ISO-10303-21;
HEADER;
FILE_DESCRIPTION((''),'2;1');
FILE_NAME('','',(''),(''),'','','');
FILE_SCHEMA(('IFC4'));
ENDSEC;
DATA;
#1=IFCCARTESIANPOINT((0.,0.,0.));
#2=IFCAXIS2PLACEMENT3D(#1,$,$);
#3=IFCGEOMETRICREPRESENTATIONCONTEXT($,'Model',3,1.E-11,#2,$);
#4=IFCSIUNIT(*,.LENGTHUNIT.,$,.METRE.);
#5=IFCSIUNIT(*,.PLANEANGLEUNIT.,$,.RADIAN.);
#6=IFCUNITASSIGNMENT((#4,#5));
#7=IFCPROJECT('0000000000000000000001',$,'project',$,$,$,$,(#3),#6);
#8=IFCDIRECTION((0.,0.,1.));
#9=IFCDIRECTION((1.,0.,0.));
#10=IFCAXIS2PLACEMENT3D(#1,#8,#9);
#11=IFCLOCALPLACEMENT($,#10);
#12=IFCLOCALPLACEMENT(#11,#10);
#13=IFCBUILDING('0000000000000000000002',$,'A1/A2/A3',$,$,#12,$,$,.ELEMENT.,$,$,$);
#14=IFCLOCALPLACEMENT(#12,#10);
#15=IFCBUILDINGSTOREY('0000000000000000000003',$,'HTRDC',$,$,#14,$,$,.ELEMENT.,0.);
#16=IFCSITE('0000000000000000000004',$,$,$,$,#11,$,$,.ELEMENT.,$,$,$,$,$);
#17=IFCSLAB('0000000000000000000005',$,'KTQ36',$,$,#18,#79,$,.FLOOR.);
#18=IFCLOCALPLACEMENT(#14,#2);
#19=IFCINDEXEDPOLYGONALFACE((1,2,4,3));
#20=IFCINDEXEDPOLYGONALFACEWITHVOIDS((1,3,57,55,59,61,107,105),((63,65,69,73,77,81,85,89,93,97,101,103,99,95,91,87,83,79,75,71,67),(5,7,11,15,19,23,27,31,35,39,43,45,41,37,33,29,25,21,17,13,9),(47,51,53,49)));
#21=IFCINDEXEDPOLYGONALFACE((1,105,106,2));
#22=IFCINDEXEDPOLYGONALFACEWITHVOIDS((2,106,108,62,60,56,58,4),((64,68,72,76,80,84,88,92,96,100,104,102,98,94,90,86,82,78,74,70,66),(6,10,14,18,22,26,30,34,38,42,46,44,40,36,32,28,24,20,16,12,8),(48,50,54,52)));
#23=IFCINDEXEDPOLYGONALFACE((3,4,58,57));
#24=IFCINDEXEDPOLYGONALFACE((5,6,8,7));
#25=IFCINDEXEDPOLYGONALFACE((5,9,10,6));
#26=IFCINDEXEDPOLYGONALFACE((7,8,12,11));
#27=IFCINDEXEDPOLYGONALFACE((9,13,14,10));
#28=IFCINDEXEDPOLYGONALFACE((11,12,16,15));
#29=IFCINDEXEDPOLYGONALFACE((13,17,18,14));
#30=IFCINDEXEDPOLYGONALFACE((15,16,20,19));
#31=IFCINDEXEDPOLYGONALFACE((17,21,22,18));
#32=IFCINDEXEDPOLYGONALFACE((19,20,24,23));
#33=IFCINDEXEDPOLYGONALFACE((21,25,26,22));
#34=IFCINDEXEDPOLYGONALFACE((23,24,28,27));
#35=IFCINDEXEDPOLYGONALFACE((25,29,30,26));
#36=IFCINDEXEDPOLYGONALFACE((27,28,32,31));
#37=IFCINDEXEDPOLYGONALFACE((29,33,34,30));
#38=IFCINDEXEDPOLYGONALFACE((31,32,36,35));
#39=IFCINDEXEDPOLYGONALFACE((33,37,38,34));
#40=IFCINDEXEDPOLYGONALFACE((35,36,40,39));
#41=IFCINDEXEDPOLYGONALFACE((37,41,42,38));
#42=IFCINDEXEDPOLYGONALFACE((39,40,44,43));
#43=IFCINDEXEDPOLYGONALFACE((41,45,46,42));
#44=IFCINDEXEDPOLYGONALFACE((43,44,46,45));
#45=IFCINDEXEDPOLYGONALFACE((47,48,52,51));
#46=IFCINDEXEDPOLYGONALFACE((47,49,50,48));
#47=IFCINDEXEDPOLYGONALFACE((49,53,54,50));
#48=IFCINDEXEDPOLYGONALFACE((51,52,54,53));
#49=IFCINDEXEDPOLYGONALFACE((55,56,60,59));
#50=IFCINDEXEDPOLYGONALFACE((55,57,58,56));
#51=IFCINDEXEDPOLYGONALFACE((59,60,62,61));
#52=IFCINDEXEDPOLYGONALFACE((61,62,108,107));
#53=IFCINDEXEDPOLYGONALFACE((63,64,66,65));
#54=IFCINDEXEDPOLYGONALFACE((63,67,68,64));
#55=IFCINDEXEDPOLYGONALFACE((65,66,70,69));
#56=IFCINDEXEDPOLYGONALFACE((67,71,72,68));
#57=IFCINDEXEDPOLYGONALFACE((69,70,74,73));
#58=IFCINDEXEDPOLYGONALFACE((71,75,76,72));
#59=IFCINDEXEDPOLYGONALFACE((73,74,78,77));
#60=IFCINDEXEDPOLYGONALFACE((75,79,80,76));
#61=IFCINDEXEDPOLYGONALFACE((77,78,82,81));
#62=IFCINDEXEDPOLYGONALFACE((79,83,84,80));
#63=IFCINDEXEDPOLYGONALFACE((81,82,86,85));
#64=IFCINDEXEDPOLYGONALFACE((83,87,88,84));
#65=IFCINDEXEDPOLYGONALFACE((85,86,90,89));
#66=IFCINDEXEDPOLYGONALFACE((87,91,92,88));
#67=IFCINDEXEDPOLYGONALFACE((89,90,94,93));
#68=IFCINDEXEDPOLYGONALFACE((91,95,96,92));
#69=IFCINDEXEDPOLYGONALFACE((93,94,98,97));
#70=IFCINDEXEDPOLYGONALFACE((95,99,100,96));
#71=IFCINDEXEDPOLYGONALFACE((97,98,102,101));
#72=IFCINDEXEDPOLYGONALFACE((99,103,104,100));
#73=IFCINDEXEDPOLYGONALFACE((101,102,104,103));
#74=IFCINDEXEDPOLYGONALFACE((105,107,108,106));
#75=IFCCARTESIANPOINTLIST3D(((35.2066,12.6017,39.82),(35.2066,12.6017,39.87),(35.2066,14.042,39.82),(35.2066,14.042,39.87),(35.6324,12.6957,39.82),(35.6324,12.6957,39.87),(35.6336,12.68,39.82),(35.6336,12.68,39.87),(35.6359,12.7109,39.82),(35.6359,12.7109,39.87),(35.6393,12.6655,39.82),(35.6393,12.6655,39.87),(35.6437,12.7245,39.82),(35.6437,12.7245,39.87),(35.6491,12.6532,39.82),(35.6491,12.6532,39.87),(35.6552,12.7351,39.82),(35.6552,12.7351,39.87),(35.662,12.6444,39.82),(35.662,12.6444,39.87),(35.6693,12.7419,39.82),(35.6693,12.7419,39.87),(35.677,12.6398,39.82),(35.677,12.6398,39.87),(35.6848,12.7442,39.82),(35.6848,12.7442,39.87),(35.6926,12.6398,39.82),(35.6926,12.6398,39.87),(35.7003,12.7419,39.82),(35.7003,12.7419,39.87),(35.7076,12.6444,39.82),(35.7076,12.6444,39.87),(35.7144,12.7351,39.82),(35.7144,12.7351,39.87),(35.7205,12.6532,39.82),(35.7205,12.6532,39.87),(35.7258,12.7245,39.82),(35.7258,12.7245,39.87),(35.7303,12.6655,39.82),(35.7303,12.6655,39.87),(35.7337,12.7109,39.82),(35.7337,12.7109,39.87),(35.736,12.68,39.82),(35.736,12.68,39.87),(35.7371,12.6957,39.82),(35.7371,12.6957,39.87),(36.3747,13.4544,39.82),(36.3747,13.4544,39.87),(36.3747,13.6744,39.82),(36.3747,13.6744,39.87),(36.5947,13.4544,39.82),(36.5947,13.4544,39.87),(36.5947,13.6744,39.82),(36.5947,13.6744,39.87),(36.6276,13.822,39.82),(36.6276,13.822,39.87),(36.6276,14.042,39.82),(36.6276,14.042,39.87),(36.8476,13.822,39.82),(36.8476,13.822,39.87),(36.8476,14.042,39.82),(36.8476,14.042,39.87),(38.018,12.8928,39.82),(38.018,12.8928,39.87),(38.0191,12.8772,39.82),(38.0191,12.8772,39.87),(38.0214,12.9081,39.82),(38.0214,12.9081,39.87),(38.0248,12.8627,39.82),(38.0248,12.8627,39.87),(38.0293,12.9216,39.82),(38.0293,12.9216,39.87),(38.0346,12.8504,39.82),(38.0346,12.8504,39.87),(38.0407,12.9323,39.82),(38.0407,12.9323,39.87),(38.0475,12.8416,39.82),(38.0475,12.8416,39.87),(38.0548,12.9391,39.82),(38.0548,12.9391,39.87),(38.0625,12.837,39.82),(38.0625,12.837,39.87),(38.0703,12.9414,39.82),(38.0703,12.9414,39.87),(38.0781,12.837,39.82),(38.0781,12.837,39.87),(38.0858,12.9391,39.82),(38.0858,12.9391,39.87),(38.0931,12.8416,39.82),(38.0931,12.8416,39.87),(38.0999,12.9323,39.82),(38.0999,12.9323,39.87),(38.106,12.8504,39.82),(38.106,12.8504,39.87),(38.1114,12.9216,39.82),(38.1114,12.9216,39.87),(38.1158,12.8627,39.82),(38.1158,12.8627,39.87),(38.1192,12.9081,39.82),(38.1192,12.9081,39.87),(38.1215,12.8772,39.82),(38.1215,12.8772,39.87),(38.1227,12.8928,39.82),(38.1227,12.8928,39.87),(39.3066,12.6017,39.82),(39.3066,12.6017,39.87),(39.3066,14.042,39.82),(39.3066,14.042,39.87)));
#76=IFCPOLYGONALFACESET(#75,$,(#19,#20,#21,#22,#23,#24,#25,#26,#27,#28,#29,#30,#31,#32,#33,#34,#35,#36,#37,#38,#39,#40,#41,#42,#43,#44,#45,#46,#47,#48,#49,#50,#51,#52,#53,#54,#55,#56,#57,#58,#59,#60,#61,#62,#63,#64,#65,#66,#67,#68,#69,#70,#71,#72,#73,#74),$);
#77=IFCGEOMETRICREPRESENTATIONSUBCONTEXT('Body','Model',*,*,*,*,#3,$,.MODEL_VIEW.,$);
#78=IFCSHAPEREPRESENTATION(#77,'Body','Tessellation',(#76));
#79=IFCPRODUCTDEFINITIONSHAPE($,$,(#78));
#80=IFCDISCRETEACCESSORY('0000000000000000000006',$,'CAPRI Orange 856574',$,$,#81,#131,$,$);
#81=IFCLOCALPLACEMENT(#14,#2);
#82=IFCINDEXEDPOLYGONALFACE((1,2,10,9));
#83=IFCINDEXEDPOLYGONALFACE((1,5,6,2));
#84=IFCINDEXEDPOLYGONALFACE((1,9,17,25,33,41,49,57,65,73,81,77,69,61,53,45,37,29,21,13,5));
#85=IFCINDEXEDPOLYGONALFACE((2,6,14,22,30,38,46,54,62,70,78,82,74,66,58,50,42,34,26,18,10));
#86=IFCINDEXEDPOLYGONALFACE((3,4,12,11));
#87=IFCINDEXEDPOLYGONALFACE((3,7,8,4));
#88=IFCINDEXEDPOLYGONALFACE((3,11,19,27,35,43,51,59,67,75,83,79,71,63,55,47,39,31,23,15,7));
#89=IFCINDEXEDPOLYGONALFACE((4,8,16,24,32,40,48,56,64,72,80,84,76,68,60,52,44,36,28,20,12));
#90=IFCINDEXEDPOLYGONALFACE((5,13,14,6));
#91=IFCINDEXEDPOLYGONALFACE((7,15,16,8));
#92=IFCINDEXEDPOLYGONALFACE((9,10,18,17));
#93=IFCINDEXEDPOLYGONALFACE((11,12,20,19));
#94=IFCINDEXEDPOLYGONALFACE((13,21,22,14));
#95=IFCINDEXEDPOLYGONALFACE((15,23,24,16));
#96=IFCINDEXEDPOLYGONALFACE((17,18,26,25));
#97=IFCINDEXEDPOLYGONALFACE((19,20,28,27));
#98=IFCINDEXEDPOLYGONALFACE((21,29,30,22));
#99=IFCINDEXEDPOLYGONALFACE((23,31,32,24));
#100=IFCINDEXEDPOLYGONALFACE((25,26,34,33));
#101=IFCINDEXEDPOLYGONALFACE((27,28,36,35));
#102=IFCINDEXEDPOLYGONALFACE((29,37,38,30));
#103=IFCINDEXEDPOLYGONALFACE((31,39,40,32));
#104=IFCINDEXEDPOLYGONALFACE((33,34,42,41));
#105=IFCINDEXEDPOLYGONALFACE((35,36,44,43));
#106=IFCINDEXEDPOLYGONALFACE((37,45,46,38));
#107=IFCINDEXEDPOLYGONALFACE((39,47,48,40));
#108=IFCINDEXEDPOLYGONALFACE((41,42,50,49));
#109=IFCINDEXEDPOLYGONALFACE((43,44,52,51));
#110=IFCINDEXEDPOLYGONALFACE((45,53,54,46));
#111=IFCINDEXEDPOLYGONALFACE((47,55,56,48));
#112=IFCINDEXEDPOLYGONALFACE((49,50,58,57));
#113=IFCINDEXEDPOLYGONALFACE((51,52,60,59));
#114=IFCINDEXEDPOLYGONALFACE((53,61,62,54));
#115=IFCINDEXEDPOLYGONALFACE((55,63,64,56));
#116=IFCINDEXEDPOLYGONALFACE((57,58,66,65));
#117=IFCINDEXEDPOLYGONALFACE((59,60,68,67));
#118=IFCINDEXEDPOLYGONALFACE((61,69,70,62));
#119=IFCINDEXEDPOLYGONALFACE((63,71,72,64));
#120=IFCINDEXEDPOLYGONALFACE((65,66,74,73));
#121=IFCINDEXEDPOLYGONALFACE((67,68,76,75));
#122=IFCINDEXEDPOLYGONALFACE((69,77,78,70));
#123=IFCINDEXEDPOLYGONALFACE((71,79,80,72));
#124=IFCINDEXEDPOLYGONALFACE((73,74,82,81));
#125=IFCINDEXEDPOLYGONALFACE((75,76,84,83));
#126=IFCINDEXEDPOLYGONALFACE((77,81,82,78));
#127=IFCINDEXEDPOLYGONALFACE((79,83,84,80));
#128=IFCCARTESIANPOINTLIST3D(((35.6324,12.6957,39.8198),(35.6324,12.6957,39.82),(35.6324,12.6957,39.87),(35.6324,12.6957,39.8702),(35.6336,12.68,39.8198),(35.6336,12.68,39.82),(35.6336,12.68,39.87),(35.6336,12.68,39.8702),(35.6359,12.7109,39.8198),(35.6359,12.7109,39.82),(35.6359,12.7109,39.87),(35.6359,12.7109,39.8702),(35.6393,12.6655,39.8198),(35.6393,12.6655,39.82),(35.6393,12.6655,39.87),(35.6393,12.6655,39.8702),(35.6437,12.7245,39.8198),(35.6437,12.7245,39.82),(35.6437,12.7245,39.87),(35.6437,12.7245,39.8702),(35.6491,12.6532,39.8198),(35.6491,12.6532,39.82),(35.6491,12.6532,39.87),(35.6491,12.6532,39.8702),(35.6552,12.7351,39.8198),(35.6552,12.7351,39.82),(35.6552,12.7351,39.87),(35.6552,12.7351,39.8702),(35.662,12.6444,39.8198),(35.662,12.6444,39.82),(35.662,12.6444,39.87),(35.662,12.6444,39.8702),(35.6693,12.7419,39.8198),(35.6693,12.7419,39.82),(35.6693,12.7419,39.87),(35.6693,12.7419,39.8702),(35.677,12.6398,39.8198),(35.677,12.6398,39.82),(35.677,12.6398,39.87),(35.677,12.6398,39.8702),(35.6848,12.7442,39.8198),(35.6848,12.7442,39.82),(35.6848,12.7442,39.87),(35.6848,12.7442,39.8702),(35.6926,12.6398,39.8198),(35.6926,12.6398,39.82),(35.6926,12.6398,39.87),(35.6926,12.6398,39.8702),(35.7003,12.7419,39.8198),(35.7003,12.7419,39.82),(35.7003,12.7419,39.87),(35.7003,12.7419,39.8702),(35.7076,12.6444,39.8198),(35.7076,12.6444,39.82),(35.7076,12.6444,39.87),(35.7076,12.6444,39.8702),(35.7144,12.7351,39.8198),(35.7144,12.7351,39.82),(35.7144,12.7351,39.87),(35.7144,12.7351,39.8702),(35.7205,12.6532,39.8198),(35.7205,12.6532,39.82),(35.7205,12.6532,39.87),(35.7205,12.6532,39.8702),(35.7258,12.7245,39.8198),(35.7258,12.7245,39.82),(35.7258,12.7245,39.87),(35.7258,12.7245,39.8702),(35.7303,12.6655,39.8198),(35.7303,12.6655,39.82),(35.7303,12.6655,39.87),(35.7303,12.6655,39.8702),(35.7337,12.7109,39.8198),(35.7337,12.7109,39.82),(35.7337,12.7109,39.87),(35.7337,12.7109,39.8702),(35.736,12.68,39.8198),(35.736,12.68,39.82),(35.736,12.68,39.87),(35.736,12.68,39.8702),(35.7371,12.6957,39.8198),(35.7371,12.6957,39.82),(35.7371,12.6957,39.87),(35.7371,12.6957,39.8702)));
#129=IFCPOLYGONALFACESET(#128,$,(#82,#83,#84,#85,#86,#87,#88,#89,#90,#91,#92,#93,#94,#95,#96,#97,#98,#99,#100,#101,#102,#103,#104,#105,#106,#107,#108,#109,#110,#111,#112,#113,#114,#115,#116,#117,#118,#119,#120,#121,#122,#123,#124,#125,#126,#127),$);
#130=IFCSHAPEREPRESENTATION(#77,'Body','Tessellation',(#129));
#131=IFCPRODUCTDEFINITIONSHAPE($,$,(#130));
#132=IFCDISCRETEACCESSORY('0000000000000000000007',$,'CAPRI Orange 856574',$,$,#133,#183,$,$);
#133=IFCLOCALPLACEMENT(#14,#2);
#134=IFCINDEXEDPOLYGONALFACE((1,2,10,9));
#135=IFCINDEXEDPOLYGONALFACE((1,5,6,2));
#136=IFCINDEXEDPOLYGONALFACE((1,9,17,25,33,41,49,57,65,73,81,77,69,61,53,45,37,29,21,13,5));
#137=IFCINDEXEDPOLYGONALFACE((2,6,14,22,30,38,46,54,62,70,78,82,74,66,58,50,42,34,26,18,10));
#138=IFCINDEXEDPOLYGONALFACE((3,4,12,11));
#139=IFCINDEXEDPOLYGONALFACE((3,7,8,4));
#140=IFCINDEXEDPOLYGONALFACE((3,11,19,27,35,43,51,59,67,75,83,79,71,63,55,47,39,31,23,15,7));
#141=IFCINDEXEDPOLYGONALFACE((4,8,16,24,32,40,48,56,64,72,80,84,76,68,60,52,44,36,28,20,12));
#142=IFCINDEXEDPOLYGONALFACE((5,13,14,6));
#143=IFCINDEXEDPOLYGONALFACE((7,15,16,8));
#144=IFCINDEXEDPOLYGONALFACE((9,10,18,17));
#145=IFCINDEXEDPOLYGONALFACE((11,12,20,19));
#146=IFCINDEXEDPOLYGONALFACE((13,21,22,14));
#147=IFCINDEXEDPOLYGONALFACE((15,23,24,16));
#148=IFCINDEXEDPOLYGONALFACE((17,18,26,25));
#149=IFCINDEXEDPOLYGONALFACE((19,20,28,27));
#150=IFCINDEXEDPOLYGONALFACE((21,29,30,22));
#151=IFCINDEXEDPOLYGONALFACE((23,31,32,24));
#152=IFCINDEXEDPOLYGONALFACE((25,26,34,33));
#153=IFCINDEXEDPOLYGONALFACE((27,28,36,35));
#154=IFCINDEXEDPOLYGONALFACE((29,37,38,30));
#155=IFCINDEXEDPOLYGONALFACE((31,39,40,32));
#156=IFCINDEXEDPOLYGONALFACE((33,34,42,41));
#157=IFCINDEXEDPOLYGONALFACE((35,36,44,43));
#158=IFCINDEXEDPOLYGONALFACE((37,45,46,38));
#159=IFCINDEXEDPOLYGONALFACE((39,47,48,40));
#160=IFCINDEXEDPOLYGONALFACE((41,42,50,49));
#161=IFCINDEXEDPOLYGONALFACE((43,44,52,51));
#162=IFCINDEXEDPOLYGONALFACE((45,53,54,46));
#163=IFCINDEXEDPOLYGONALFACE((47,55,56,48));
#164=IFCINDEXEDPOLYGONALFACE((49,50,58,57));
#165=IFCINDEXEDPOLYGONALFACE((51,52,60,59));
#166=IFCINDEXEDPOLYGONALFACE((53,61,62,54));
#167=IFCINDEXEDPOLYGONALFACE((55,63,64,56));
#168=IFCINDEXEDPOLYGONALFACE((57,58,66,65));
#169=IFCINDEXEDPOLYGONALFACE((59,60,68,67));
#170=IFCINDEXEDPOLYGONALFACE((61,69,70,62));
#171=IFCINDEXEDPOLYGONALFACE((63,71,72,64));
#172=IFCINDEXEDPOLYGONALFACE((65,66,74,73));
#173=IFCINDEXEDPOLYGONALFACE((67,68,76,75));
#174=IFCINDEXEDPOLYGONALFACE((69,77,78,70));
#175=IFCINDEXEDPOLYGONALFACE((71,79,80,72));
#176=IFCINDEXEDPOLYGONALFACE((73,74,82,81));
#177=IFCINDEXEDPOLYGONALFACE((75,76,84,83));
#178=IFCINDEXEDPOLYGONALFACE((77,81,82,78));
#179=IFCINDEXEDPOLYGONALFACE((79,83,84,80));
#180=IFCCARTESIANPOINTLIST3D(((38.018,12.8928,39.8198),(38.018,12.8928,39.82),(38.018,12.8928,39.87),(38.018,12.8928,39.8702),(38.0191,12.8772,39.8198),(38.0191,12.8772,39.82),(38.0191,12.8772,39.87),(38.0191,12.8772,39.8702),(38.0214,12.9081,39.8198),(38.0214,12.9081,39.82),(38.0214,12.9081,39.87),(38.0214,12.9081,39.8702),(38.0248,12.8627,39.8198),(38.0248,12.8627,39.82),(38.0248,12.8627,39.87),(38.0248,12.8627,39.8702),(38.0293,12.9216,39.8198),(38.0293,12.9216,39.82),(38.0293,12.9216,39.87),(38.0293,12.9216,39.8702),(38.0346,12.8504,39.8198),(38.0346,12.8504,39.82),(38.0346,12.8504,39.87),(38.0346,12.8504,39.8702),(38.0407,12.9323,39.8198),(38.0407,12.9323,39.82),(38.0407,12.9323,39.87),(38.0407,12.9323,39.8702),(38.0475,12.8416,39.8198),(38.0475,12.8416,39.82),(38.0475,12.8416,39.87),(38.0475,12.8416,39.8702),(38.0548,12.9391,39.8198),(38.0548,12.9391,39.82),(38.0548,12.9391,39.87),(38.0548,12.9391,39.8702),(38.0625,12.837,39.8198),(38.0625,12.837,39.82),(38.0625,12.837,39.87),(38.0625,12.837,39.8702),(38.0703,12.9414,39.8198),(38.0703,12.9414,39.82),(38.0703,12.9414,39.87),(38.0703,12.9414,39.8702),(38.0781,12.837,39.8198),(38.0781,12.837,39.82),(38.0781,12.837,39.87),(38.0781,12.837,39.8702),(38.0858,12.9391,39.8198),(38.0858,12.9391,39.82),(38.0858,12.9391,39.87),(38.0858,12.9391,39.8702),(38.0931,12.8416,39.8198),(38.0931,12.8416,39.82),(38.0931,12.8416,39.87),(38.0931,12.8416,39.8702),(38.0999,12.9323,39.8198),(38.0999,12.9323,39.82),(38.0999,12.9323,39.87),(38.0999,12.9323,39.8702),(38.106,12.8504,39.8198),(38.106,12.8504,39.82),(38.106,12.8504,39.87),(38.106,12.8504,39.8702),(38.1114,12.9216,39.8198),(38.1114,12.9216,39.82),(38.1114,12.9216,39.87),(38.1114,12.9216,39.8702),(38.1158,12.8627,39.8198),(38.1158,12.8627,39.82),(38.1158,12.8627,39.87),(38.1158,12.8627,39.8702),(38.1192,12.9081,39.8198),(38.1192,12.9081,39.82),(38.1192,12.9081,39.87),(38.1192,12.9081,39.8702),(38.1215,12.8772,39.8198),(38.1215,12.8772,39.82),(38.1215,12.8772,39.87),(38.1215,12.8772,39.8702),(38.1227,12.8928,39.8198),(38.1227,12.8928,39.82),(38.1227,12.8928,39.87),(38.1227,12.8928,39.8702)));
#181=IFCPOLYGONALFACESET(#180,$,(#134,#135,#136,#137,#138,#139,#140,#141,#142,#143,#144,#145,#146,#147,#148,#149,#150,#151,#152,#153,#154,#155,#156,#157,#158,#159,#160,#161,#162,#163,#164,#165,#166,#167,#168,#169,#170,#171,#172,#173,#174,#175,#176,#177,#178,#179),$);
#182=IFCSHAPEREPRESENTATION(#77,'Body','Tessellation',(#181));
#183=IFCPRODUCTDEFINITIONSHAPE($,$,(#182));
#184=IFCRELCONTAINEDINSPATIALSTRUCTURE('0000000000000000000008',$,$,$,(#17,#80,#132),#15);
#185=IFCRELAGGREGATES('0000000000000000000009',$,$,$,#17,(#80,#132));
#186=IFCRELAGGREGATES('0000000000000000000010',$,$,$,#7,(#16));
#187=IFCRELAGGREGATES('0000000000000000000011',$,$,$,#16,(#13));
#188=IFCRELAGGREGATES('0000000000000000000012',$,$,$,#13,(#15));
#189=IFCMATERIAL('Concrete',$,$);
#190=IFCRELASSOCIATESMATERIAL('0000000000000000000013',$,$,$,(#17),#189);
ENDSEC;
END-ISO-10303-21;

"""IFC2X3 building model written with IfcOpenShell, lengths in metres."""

from ifc_helpers import new_model, si_unit, frame, frame_2d, origin, origin_with_axes, origin_2d_with_axis, place, context, subcontext, project, spatial, polyline, circle, outline, extrude, material, element, aggregate, save


model = new_model("IFC2X3")

# Units and contexts
model_context = context("Model", 3, precision=1e-11, world=origin())
body_context = subcontext(model_context, "Body", "Model", "MODEL_VIEW")
ifc_project = project(units=[si_unit("LENGTHUNIT", "METRE"), si_unit("PLANEANGLEUNIT", "RADIAN")], contexts=[model_context])

# Site, building, storey
site_placement = place(None, origin_with_axes())
site = spatial("IfcSite", under=ifc_project, at=site_placement, CompositionType="ELEMENT")
building_placement = place(site_placement, origin_with_axes())
building = spatial("IfcBuilding", under=site, at=building_placement, Name="A1/A2/A3", CompositionType="ELEMENT")
storey_placement = place(building_placement, origin_with_axes())
storey = spatial("IfcBuildingStorey", under=building, at=storey_placement, Name="HTRDC", CompositionType="ELEMENT", Elevation=0.0)

# Shared definitions
ifc_material = material(Name="Concrete")

# Slab, openings
slab_1_placement = place(storey_placement, frame((35.2066, 12.6017, 39.82), z_axis=(0.0, 0.0, 1.0), x_axis=(1.0, 0.0, 0.0)))
slab_1 = element("IfcSlab", 1, at=slab_1_placement, inside=storey, material=ifc_material, Name="KTQ36", PredefinedType="FLOOR", context=body_context, shape_type="SweptSolid", body=[
    extrude(outline(polyline([(0.0, 0.0), (0.0, -4.1), (1.4403, -4.1), (1.4403, 0.0), (0.0, 0.0)])), frame((0.0, 0.0, 0.0), z_axis=(0.0, 0.0, 1.0), x_axis=(0.0, 1.0, 0.0)), (0.0, 0.0, 1.0), 0.05),
])
opening_1_placement = place(slab_1_placement, origin_with_axes())
element("IfcOpeningElement", 2, at=opening_1_placement, cuts=slab_1, ObjectType="Opening", context=body_context, shape_type="SweptSolid", body=[
    extrude(outline(polyline([(1.2203, -1.421), (1.2203, -1.641), (1.4403, -1.641), (1.4403, -1.421), (1.2203, -1.421)])), frame((0.0, 0.0, 0.0), z_axis=(0.0, 0.0, 1.0), x_axis=(0.0, 1.0, 0.0)), (0.0, 0.0, 1.0), 0.05),
])
opening_2_placement = place(slab_1_placement, origin_with_axes())
element("IfcOpeningElement", 3, at=opening_2_placement, cuts=slab_1, ObjectType="Opening", context=body_context, shape_type="SweptSolid", body=[
    extrude(outline(polyline([(0.8526, -1.1682), (0.8526, -1.3882), (1.0726, -1.3882), (1.0726, -1.1682), (0.8526, -1.1682)])), frame((0.0, 0.0, 0.0), z_axis=(0.0, 0.0, 1.0), x_axis=(0.0, 1.0, 0.0)), (0.0, 0.0, 1.0), 0.05),
])
opening_3_placement = place(slab_1_placement, frame((0.4782, 0.09, 0.0), z_axis=(0.0, 0.0, 1.0), x_axis=(1.0, 0.0, 0.0)))
element("IfcOpeningElement", 4, at=opening_3_placement, cuts=slab_1, ObjectType="Opening", context=body_context, shape_type="SweptSolid", body=[
    extrude(circle(Radius=0.0525, at=origin_2d_with_axis()), frame((0.0, 0.0, 0.0), z_axis=(0.0, 0.0, 1.0), x_axis=(0.0, 1.0, 0.0)), (0.0, 0.0, 1.0), 0.05),
])
opening_4_placement = place(slab_1_placement, frame((2.8638, 0.2872, 0.0), z_axis=(0.0, 0.0, 1.0), x_axis=(1.0, 0.0, 0.0)))
element("IfcOpeningElement", 5, at=opening_4_placement, cuts=slab_1, ObjectType="Opening", context=body_context, shape_type="SweptSolid", body=[
    extrude(circle(Radius=0.0525, at=origin_2d_with_axis()), frame((0.0, 0.0, 0.0), z_axis=(0.0, 0.0, 1.0), x_axis=(0.0, 1.0, 0.0)), (0.0, 0.0, 1.0), 0.05),
])

# Discrete accessories
discrete_accessory_1_placement = place(storey_placement, frame((35.2066, 12.6017, 39.8199), z_axis=(0.0, 0.0, 1.0), x_axis=(1.0, 0.0, 0.0)))
discrete_accessory_1 = element("IfcDiscreteAccessory", 6, at=discrete_accessory_1_placement, inside=storey, Name="CAPRI Orange 856574", context=body_context, shape_type="SweptSolid", body=[
    extrude(circle(Radius=0.0525, at=frame_2d((0.09, -0.4782), x_axis=(1.0, 0.0))), frame((0.0, 0.0, 0.0), z_axis=(0.0, 0.0, 1.0), x_axis=(0.0, 1.0, 0.0)), (0.0, 0.0, 1.0), 0.0503),
])
discrete_accessory_2_placement = place(storey_placement, frame((35.2066, 12.6017, 39.8199), z_axis=(0.0, 0.0, 1.0), x_axis=(1.0, 0.0, 0.0)))
discrete_accessory_2 = element("IfcDiscreteAccessory", 7, at=discrete_accessory_2_placement, inside=storey, Name="CAPRI Orange 856574", context=body_context, shape_type="SweptSolid", body=[
    extrude(circle(Radius=0.0525, at=frame_2d((0.2872, -2.8638), x_axis=(1.0, 0.0))), frame((0.0, 0.0, 0.0), z_axis=(0.0, 0.0, 1.0), x_axis=(0.0, 1.0, 0.0)), (0.0, 0.0, 1.0), 0.0503),
])
aggregate(slab_1, [discrete_accessory_1, discrete_accessory_2])

save(model, "model.ifc")
